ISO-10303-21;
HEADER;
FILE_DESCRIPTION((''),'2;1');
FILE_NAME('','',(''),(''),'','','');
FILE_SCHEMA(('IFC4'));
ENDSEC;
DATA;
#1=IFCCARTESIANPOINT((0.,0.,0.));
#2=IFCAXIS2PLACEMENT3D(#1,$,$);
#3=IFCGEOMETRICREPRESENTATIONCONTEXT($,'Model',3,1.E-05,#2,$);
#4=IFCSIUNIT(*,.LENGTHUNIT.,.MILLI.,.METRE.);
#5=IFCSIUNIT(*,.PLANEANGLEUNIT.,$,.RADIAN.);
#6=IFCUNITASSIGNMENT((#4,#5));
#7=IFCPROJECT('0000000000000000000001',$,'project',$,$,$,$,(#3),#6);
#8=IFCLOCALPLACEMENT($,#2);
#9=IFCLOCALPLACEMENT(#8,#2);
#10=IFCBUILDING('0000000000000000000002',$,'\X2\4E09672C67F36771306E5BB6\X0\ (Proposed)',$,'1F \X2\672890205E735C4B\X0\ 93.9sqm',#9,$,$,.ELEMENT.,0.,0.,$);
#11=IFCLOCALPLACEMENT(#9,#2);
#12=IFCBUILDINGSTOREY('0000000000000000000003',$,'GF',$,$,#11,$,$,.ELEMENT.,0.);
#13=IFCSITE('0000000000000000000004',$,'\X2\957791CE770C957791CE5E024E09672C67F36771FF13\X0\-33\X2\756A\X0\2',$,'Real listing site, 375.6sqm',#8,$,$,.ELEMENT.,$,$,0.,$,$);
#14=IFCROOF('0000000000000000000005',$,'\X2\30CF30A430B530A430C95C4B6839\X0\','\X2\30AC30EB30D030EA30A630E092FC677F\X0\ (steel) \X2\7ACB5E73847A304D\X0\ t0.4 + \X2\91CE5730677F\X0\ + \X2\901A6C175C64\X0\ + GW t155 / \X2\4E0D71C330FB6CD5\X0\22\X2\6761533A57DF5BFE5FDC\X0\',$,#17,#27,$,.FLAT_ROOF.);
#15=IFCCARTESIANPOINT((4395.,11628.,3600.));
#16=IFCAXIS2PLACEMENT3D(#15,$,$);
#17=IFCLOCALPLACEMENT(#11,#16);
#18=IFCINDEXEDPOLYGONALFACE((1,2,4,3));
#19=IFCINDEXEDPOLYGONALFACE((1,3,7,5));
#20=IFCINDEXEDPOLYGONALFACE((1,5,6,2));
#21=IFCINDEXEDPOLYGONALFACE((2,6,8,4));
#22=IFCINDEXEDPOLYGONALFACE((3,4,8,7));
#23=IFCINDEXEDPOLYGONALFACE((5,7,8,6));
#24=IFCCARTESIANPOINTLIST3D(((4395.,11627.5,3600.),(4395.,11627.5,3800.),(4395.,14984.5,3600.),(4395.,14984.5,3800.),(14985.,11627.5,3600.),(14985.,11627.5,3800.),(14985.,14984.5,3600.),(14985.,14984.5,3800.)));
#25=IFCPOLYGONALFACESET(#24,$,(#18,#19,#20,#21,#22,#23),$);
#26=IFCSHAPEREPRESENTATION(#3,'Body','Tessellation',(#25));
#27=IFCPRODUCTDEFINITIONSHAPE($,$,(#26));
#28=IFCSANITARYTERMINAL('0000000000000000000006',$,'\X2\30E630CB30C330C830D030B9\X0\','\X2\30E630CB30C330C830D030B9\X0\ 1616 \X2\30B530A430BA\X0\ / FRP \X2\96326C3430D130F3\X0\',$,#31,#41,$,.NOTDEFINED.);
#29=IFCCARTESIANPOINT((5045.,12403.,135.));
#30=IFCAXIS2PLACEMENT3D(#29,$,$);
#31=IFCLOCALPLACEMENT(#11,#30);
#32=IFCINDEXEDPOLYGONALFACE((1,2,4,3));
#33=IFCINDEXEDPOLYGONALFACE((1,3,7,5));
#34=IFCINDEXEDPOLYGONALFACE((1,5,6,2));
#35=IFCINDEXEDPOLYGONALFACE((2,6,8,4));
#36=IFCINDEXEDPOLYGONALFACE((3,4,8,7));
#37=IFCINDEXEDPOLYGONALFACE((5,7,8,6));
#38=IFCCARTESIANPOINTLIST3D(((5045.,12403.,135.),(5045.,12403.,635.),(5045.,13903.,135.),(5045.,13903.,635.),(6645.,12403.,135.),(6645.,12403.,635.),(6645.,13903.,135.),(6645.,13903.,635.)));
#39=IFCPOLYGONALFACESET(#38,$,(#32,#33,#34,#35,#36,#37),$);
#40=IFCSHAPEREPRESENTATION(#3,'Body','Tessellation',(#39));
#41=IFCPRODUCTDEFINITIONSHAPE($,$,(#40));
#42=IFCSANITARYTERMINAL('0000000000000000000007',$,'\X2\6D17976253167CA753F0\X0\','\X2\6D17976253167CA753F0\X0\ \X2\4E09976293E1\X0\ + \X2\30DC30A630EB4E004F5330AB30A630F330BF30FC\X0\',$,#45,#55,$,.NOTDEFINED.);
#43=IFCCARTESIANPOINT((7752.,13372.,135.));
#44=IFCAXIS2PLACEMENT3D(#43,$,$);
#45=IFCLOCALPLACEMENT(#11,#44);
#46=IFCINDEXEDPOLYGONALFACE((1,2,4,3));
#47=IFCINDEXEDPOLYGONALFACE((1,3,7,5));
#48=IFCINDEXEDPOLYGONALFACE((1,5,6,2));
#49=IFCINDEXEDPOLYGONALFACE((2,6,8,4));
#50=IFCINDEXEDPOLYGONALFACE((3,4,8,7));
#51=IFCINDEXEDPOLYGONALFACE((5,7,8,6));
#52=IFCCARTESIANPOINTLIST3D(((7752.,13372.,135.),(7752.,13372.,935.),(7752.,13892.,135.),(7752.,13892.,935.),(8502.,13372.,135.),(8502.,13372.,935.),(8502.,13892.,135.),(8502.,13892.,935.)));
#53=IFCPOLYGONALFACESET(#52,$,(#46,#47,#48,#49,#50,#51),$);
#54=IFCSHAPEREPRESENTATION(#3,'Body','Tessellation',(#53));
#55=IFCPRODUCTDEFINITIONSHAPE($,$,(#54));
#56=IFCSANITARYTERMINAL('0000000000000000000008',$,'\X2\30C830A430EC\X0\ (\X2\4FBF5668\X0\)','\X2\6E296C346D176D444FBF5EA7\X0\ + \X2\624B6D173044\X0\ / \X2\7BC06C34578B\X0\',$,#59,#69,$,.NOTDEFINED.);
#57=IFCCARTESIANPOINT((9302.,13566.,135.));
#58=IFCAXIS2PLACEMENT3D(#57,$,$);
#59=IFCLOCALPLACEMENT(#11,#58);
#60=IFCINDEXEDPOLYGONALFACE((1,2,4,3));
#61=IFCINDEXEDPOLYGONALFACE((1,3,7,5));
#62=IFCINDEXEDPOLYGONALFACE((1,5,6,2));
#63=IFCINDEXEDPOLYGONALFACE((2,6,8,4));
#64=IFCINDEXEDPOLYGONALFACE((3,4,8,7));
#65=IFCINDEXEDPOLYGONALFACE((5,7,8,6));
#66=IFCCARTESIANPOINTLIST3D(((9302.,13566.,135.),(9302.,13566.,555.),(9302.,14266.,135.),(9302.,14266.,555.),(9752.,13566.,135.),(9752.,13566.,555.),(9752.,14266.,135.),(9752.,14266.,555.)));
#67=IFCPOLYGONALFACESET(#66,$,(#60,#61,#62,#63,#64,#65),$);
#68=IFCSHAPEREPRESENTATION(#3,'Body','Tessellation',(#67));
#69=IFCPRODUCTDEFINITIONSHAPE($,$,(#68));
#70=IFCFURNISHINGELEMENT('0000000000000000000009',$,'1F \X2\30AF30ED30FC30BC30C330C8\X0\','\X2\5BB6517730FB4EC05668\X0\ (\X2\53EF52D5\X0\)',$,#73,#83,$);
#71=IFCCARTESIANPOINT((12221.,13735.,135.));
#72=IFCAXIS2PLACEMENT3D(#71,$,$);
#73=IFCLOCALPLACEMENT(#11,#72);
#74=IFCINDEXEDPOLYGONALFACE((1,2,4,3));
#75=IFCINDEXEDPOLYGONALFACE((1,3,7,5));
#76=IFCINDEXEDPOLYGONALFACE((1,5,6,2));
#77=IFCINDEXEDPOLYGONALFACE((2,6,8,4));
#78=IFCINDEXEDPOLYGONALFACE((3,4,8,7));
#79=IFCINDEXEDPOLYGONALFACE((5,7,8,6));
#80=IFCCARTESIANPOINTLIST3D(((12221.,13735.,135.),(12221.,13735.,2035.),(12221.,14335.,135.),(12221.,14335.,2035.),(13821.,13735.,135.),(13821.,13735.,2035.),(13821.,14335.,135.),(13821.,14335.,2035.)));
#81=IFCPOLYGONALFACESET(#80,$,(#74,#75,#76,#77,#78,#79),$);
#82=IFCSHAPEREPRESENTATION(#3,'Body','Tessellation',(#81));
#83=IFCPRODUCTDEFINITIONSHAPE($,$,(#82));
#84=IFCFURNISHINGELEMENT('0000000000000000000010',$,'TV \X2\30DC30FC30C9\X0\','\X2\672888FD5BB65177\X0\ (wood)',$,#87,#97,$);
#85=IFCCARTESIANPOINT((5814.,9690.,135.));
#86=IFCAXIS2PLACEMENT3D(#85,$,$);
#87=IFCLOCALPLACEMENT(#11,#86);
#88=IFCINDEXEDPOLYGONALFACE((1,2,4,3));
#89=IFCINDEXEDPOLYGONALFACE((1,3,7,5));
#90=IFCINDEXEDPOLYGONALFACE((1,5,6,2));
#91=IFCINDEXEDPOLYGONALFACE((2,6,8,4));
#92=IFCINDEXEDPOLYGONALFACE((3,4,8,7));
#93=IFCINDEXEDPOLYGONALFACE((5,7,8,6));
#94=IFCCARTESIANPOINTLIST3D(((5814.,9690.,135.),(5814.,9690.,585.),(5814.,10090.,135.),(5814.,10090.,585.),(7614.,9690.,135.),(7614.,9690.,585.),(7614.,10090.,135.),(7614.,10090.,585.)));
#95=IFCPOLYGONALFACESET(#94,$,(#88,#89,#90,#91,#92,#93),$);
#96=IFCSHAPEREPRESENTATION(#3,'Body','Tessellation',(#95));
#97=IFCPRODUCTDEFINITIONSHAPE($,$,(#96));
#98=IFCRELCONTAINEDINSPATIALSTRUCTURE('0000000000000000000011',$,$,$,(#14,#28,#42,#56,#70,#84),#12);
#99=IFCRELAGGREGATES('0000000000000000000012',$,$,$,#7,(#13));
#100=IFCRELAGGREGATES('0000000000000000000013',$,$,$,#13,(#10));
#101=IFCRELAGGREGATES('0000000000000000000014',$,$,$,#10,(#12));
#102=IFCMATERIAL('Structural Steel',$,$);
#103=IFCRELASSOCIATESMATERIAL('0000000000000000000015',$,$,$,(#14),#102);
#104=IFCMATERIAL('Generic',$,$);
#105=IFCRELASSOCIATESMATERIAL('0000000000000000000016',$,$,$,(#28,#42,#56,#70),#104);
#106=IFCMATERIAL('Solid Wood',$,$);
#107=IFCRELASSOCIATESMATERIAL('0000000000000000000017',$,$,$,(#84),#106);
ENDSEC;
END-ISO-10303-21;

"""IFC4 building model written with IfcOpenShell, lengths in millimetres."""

from ifc_helpers import new_model, si_unit, frame, frame_2d, origin, place, context, project, spatial, rectangle, extrude, material, element, save


model = new_model("IFC4")

# Units and contexts
model_context = context("Model", 3, precision=1e-05, world=origin())
ifc_project = project(units=[si_unit("LENGTHUNIT", "METRE", prefix="MILLI"), si_unit("PLANEANGLEUNIT", "RADIAN")], contexts=[model_context])

# Site, building, storey
site_placement = place(None, origin())
site = spatial("IfcSite", under=ifc_project, at=site_placement, Name="長野県長野市三本柳東３-33番2", ObjectType="Real listing site, 375.6sqm", CompositionType="ELEMENT", RefElevation=0.0)
building_placement = place(site_placement, origin())
building = spatial("IfcBuilding", under=site, at=building_placement, Name="三本柳東の家 (Proposed)", ObjectType="1F 木造平屋 93.9sqm", CompositionType="ELEMENT", ElevationOfRefHeight=0.0, ElevationOfTerrain=0.0)
storey_placement = place(building_placement, origin())
storey = spatial("IfcBuildingStorey", under=building, at=storey_placement, Name="GF", CompositionType="ELEMENT", Elevation=0.0)

# Shared definitions
ifc_material_1 = material(Name="Solid Wood")

# Roof
ifc_material_2 = material(Name="Structural Steel")
roof_placement = place(storey_placement, frame((4395.0, 11628.0, 3600.0)))
element("IfcRoof", 1, at=roof_placement, inside=storey, material=ifc_material_2, Name="ハイサイド屋根", Description="ガルバリウム鋼板 (steel) 立平葺き t0.4 + 野地板 + 通気層 + GW t155 / 不燃・法22条区域対応", PredefinedType="FLAT_ROOF", context=model_context, shape_type="SweptSolid", body=[
    extrude(rectangle(XDim=10590.0, YDim=3357.0, at=frame_2d((5295.0, 1678.0))), frame((4395.0, 11628.0, 3600.0)), (0.0, 0.0, 1.0), 200.0),
])

# Sanitary terminals
ifc_material_3 = material(Name="Generic")
sanitary_terminal_1_placement = place(storey_placement, frame((5045.0, 12403.0, 135.0)))
element("IfcSanitaryTerminal", 2, at=sanitary_terminal_1_placement, inside=storey, material=ifc_material_3, Name="ユニットバス", Description="ユニットバス 1616 サイズ / FRP 防水パン", PredefinedType="NOTDEFINED", context=model_context, shape_type="SweptSolid", body=[
    extrude(rectangle(XDim=1600.0, YDim=1500.0, at=frame_2d((800.0, 750.0))), frame((5045.0, 12403.0, 135.0)), (0.0, 0.0, 1.0), 500.0),
])
sanitary_terminal_2_placement = place(storey_placement, frame((7752.0, 13372.0, 135.0)))
element("IfcSanitaryTerminal", 3, at=sanitary_terminal_2_placement, inside=storey, material=ifc_material_3, Name="洗面化粧台", Description="洗面化粧台 三面鏡 + ボウル一体カウンター", PredefinedType="NOTDEFINED", context=model_context, shape_type="SweptSolid", body=[
    extrude(rectangle(XDim=750.0, YDim=520.0, at=frame_2d((375.0, 260.0))), frame((7752.0, 13372.0, 135.0)), (0.0, 0.0, 1.0), 800.0),
])
sanitary_terminal_3_placement = place(storey_placement, frame((9302.0, 13566.0, 135.0)))
element("IfcSanitaryTerminal", 4, at=sanitary_terminal_3_placement, inside=storey, material=ifc_material_3, Name="トイレ (便器)", Description="温水洗浄便座 + 手洗い / 節水型", PredefinedType="NOTDEFINED", context=model_context, shape_type="SweptSolid", body=[
    extrude(rectangle(XDim=450.0, YDim=700.0, at=frame_2d((225.0, 350.0))), frame((9302.0, 13566.0, 135.0)), (0.0, 0.0, 1.0), 420.0),
])

# Furnishing elements
furnishing_1_placement = place(storey_placement, frame((12221.0, 13735.0, 135.0)))
element("IfcFurnishingElement", 5, at=furnishing_1_placement, inside=storey, material=ifc_material_3, Name="1F クローゼット", Description="家具・什器 (可動)", context=model_context, shape_type="SweptSolid", body=[
    extrude(rectangle(XDim=1600.0, YDim=600.0, at=frame_2d((800.0, 300.0))), frame((12221.0, 13735.0, 135.0)), (0.0, 0.0, 1.0), 1900.0),
])
furnishing_2_placement = place(storey_placement, frame((5814.0, 9690.0, 135.0)))
element("IfcFurnishingElement", 6, at=furnishing_2_placement, inside=storey, material=ifc_material_1, Name="TV ボード", Description="木製家具 (wood)", context=model_context, shape_type="SweptSolid", body=[
    extrude(rectangle(XDim=1800.0, YDim=400.0, at=frame_2d((900.0, 200.0))), frame((5814.0, 9690.0, 135.0)), (0.0, 0.0, 1.0), 450.0),
])

save(model, "model.ifc")
